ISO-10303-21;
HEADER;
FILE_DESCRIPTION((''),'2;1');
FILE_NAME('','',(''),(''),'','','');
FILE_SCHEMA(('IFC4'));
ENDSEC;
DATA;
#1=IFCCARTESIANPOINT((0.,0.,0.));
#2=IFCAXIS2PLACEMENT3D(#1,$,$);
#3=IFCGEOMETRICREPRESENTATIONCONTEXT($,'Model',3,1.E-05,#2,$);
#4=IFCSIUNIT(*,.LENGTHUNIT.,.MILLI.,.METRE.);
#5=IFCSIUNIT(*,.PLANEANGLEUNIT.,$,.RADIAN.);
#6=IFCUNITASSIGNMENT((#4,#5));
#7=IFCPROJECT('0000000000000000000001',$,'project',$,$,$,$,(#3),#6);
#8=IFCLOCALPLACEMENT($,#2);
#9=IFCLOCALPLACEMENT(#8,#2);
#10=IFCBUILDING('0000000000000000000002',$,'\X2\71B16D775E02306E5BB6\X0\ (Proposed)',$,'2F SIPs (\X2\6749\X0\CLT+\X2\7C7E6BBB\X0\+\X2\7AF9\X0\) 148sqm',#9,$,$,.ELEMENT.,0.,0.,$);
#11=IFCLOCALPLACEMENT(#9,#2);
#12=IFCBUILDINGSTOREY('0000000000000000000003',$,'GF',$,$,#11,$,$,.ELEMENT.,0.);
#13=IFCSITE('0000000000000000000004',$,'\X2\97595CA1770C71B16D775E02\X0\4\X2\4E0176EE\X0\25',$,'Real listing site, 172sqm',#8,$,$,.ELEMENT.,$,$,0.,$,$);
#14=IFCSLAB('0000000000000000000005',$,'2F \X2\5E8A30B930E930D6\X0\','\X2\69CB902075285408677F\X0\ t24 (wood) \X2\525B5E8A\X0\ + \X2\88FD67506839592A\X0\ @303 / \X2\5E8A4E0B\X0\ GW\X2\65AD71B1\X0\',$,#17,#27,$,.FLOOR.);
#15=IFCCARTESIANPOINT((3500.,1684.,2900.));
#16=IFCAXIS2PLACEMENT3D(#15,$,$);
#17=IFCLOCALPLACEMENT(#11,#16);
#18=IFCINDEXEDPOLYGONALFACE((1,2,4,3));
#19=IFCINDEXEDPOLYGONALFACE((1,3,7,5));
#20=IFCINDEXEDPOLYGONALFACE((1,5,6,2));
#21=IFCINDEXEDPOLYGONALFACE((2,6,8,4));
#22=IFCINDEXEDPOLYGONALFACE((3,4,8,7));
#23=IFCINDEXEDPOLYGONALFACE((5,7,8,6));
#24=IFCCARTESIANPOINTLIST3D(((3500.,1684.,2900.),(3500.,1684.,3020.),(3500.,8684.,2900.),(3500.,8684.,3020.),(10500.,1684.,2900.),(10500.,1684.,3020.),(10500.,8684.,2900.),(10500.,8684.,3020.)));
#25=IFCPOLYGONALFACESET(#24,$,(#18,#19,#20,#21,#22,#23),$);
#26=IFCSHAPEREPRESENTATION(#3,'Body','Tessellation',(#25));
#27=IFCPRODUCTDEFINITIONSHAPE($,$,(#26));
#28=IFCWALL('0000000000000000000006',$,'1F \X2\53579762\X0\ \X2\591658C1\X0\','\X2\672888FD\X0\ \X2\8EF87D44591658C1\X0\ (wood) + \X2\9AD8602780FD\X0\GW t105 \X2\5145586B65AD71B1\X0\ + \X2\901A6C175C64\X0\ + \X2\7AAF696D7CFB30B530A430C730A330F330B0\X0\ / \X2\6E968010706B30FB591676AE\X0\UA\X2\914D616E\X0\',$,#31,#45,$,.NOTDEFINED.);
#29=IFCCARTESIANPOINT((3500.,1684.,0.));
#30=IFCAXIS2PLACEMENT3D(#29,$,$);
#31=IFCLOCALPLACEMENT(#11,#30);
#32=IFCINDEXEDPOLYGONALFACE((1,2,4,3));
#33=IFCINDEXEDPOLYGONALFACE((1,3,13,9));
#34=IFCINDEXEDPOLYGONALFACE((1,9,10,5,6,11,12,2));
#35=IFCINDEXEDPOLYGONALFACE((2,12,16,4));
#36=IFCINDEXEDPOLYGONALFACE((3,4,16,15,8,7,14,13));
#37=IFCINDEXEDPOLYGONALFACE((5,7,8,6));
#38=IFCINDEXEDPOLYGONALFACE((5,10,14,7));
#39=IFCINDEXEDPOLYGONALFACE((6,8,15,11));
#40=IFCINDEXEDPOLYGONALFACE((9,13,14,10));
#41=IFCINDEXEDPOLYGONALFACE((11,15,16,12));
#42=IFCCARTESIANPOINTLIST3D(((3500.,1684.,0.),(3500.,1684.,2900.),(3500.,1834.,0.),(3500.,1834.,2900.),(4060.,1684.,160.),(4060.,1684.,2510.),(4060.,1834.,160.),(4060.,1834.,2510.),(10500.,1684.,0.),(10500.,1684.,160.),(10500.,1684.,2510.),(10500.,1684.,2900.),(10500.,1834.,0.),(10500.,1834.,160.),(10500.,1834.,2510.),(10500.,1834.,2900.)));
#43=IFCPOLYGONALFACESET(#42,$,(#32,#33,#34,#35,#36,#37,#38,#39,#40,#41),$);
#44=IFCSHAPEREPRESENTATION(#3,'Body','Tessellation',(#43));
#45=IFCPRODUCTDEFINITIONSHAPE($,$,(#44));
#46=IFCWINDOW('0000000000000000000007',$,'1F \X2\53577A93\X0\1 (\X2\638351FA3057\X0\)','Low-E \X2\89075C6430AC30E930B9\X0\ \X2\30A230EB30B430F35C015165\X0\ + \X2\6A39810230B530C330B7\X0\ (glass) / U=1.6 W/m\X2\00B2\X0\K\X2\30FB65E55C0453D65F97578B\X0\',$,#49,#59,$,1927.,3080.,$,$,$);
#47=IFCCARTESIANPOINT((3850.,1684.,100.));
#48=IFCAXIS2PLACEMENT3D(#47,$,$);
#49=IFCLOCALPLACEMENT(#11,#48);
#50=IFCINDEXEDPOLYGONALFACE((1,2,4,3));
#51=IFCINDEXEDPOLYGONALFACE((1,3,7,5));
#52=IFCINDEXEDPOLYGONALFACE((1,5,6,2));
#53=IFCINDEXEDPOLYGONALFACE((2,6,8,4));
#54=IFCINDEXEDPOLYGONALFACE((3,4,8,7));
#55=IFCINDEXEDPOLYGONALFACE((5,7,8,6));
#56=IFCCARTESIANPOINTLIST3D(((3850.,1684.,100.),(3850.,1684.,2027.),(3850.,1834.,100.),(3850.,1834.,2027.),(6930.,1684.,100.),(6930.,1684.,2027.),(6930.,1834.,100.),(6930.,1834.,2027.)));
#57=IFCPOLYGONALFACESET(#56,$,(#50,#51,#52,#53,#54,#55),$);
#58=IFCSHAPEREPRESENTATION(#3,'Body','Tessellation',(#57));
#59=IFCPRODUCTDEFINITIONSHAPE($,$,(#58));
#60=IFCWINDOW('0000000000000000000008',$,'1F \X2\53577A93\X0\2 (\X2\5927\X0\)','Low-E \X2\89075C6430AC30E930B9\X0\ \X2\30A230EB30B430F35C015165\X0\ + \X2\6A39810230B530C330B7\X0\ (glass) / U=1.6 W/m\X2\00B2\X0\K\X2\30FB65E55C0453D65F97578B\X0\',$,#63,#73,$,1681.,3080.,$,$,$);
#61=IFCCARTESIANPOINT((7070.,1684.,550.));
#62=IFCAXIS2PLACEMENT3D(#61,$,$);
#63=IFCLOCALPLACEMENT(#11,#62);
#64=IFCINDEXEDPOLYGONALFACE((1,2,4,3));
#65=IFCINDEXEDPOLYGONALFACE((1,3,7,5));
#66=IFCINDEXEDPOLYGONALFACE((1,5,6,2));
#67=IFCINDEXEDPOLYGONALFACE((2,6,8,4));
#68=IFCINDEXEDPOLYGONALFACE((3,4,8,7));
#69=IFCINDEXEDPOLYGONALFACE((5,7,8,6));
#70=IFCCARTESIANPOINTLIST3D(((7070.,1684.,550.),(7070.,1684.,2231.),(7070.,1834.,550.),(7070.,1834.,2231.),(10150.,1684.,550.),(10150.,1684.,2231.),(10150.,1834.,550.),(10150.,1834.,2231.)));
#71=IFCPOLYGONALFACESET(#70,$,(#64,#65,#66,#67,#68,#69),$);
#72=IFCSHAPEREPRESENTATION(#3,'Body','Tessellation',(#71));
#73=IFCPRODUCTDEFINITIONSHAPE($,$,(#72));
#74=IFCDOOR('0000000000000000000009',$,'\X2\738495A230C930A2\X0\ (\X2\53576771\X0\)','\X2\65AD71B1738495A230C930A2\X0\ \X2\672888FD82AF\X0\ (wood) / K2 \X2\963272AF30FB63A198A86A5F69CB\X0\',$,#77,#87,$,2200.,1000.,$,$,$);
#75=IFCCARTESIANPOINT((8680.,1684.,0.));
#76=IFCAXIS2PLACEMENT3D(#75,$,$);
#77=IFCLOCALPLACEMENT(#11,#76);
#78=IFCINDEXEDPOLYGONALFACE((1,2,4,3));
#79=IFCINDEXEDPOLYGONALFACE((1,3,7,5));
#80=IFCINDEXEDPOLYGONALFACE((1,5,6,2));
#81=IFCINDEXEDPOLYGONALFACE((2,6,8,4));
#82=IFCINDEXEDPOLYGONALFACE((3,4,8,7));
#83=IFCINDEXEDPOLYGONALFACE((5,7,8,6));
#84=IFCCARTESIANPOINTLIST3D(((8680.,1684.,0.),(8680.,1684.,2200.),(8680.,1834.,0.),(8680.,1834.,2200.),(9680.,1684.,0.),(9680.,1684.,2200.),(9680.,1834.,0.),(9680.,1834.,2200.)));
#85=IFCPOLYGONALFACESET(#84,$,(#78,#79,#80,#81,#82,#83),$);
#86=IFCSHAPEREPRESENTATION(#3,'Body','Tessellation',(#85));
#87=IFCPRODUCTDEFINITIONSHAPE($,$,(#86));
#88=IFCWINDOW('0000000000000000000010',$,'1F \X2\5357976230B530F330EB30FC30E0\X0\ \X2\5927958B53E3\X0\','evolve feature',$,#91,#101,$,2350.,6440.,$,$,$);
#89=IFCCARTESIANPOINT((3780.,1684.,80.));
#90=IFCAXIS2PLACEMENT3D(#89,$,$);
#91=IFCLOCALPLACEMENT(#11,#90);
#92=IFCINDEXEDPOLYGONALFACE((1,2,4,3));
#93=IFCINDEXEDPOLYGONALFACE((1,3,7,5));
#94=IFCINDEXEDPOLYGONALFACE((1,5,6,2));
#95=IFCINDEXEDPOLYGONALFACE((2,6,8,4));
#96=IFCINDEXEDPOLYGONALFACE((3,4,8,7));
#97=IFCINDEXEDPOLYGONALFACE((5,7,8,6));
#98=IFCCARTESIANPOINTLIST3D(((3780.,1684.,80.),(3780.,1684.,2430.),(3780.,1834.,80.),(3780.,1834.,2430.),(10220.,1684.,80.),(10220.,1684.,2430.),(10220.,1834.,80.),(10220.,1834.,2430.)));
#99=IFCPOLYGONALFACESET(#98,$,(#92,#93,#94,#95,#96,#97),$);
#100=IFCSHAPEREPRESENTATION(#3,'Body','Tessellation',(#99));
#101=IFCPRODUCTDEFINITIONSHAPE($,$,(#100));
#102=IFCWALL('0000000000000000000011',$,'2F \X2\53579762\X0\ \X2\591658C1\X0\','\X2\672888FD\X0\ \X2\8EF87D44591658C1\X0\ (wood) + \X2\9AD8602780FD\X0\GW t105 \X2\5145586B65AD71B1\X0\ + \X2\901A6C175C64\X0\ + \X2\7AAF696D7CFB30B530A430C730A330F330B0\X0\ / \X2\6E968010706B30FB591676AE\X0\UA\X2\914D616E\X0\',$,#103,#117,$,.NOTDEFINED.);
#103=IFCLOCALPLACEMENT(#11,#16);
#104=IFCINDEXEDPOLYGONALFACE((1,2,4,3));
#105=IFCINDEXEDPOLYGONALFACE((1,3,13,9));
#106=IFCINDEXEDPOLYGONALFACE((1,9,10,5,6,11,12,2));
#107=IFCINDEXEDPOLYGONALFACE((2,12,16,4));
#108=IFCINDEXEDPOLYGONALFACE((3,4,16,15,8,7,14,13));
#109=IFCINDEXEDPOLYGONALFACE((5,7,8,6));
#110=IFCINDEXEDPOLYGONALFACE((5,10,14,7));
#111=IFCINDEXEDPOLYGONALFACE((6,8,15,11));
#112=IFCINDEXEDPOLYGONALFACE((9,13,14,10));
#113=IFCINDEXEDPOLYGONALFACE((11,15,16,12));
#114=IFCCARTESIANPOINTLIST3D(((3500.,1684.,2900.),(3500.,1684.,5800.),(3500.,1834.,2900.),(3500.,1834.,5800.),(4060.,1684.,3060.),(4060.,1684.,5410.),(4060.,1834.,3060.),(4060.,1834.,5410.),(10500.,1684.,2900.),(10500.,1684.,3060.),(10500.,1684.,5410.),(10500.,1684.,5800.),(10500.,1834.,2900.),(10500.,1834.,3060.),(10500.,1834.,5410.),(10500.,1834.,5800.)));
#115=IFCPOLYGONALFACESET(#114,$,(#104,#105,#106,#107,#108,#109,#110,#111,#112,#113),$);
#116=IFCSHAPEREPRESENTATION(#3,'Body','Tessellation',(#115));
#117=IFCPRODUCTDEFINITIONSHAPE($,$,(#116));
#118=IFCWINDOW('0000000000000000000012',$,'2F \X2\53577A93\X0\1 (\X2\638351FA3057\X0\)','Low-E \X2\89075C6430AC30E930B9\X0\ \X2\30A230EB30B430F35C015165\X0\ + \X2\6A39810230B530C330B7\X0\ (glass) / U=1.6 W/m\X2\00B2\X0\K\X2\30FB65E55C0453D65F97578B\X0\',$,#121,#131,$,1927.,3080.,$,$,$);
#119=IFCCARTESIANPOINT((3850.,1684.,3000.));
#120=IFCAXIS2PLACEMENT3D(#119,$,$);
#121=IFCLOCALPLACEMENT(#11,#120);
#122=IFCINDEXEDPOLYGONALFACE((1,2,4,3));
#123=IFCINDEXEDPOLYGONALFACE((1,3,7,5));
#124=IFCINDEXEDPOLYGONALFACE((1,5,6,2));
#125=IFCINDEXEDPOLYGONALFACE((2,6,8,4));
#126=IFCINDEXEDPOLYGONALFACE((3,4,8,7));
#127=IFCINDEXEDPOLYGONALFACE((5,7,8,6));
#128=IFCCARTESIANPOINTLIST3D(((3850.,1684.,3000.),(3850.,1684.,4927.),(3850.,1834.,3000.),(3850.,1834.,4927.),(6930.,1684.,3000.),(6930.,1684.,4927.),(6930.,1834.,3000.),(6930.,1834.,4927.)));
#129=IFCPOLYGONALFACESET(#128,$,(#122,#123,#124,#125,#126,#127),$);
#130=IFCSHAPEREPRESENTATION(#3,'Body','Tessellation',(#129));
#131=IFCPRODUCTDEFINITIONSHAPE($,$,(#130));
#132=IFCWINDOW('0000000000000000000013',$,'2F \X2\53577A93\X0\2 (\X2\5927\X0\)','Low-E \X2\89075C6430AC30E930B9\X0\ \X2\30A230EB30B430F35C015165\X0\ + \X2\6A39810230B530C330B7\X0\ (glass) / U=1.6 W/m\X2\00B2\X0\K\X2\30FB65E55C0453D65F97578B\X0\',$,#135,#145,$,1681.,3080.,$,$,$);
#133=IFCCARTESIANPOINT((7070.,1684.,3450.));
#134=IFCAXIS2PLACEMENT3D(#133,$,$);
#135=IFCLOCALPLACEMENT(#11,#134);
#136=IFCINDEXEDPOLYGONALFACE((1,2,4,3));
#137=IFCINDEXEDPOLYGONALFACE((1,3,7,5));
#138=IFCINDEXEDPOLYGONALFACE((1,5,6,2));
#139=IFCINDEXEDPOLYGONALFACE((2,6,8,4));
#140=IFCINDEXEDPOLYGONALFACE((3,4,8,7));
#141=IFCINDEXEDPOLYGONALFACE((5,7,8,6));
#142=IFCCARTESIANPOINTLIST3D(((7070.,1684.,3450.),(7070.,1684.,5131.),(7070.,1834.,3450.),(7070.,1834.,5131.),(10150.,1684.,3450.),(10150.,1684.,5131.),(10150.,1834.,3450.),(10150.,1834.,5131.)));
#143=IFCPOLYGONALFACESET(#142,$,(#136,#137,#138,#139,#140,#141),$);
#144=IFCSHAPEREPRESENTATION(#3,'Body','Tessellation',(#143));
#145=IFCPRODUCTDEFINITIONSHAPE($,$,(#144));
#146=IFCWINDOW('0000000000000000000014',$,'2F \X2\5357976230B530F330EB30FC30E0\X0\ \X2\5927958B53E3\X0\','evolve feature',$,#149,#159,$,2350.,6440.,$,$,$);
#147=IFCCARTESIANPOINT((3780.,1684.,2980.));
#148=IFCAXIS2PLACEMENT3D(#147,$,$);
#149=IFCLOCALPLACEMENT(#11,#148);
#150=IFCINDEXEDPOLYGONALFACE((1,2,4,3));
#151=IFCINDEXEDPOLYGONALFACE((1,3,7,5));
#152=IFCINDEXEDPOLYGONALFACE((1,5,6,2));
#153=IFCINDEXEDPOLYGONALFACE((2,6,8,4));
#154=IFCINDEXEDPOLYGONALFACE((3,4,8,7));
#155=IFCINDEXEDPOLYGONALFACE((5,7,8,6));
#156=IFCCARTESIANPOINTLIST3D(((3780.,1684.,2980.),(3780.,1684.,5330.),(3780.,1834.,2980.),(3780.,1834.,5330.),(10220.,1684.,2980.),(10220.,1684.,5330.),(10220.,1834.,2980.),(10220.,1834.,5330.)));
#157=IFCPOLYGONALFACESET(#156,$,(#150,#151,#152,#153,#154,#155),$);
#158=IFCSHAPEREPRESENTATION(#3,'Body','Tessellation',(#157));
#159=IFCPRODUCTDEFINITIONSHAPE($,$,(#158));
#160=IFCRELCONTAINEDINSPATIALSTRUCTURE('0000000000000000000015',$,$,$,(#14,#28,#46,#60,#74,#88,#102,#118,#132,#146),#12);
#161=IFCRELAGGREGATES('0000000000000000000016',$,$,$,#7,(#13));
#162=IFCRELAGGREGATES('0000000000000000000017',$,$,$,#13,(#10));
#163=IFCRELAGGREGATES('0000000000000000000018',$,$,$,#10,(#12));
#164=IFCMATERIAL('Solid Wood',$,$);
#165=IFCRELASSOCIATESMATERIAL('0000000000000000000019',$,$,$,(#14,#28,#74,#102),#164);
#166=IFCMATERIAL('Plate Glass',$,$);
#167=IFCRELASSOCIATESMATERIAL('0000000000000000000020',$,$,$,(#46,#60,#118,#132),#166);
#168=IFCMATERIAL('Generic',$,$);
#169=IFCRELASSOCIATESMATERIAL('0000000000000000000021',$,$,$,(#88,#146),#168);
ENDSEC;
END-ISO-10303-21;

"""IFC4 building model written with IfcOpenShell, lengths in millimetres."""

from ifc_helpers import new_model, si_unit, frame, frame_2d, origin, place, context, project, spatial, rectangle, extrude, material, element, fill, save


model = new_model("IFC4")

# Units and contexts
model_context = context("Model", 3, precision=1e-05, world=origin())
ifc_project = project(units=[si_unit("LENGTHUNIT", "METRE", prefix="MILLI"), si_unit("PLANEANGLEUNIT", "RADIAN")], contexts=[model_context])

# Site, building, storey
site_placement = place(None, origin())
site = spatial("IfcSite", under=ifc_project, at=site_placement, Name="静岡県熱海市4丁目25", ObjectType="Real listing site, 172sqm", CompositionType="ELEMENT", RefElevation=0.0)
building_placement = place(site_placement, origin())
building = spatial("IfcBuilding", under=site, at=building_placement, Name="熱海市の家 (Proposed)", ObjectType="2F SIPs (杉CLT+籾殻+竹) 148sqm", CompositionType="ELEMENT", ElevationOfRefHeight=0.0, ElevationOfTerrain=0.0)
storey_placement = place(building_placement, origin())
storey = spatial("IfcBuildingStorey", under=building, at=storey_placement, Name="GF", CompositionType="ELEMENT", Elevation=0.0)

# Slab
ifc_material_1 = material(Name="Solid Wood")
slab_1_placement = place(storey_placement, frame((3500.0, 1684.0, 2900.0)))
element("IfcSlab", 1, at=slab_1_placement, inside=storey, material=ifc_material_1, Name="2F 床スラブ", Description="構造用合板 t24 (wood) 剛床 + 製材根太 @303 / 床下 GW断熱", PredefinedType="FLOOR", context=model_context, shape_type="SweptSolid", body=[
    extrude(rectangle(XDim=7000.0, YDim=7000.0, at=frame_2d((3500.0, 3500.0))), frame((3500.0, 1684.0, 2900.0)), (0.0, 0.0, 1.0), 120.0),
])
ifc_material_2 = material(Name="Generic")

# Wall, openings, windows, door
wall_1_placement = place(storey_placement, frame((3500.0, 1684.0, 0.0)))
wall_1 = element("IfcWall", 2, at=wall_1_placement, inside=storey, material=ifc_material_1, Name="1F 南面 外壁", Description="木製 軸組外壁 (wood) + 高性能GW t105 充填断熱 + 通気層 + 窯業系サイディング / 準耐火・外皮UA配慮", PredefinedType="NOTDEFINED", context=model_context, shape_type="SweptSolid", body=[
    extrude(rectangle(XDim=7000.0, YDim=150.0, at=frame_2d((3500.0, 75.0))), frame((3500.0, 1684.0, 0.0)), (0.0, 0.0, 1.0), 2900.0),
])
opening_1_placement = place(storey_placement, frame((3850.0, 1684.0, 100.0)))
opening_1 = element("IfcOpeningElement", 3, at=opening_1_placement, cuts=wall_1, PredefinedType="NOTDEFINED", context=model_context, shape_type="SweptSolid", body=[
    extrude(rectangle(XDim=3080.0, YDim=150.0, at=frame_2d((1540.0, 75.0))), frame((3850.0, 1684.0, 100.0)), (0.0, 0.0, 1.0), 1927.0),
])
opening_2_placement = place(storey_placement, frame((7070.0, 1684.0, 550.0)))
opening_2 = element("IfcOpeningElement", 4, at=opening_2_placement, cuts=wall_1, PredefinedType="NOTDEFINED", context=model_context, shape_type="SweptSolid", body=[
    extrude(rectangle(XDim=3080.0, YDim=150.0, at=frame_2d((1540.0, 75.0))), frame((7070.0, 1684.0, 550.0)), (0.0, 0.0, 1.0), 1681.0),
])
opening_3_placement = place(storey_placement, frame((8680.0, 1684.0, 0.0)))
opening_3 = element("IfcOpeningElement", 5, at=opening_3_placement, cuts=wall_1, PredefinedType="NOTDEFINED", context=model_context, shape_type="SweptSolid", body=[
    extrude(rectangle(XDim=1000.0, YDim=150.0, at=frame_2d((500.0, 75.0))), frame((8680.0, 1684.0, 0.0)), (0.0, 0.0, 1.0), 2200.0),
])
opening_4_placement = place(storey_placement, frame((3780.0, 1684.0, 80.0)))
opening_4 = element("IfcOpeningElement", 6, at=opening_4_placement, cuts=wall_1, PredefinedType="NOTDEFINED", context=model_context, shape_type="SweptSolid", body=[
    extrude(rectangle(XDim=6440.0, YDim=150.0, at=frame_2d((3220.0, 75.0))), frame((3780.0, 1684.0, 80.0)), (0.0, 0.0, 1.0), 2350.0),
])
ifc_material_3 = material(Name="Plate Glass")
window_1_placement = place(storey_placement, frame((3850.0, 1684.0, 100.0)))
window_1 = element("IfcWindow", 7, at=window_1_placement, inside=storey, material=ifc_material_3, Name="1F 南窓1 (掃出し)", Description="Low-E 複層ガラス アルゴン封入 + 樹脂サッシ (glass) / U=1.6 W/m²K・日射取得型", OverallHeight=1927.0, OverallWidth=3080.0, context=model_context, shape_type="SweptSolid", body=[
    extrude(rectangle(XDim=3080.0, YDim=150.0, at=frame_2d((1540.0, 75.0))), frame((3850.0, 1684.0, 100.0)), (0.0, 0.0, 1.0), 1927.0),
])
fill(opening_1, window_1)
window_2_placement = place(storey_placement, frame((7070.0, 1684.0, 550.0)))
window_2 = element("IfcWindow", 8, at=window_2_placement, inside=storey, material=ifc_material_3, Name="1F 南窓2 (大)", Description="Low-E 複層ガラス アルゴン封入 + 樹脂サッシ (glass) / U=1.6 W/m²K・日射取得型", OverallHeight=1681.0, OverallWidth=3080.0, context=model_context, shape_type="SweptSolid", body=[
    extrude(rectangle(XDim=3080.0, YDim=150.0, at=frame_2d((1540.0, 75.0))), frame((7070.0, 1684.0, 550.0)), (0.0, 0.0, 1.0), 1681.0),
])
fill(opening_2, window_2)
door_placement = place(storey_placement, frame((8680.0, 1684.0, 0.0)))
door = element("IfcDoor", 9, at=door_placement, inside=storey, material=ifc_material_1, Name="玄関ドア (南東)", Description="断熱玄関ドア 木製芯 (wood) / K2 防犯・採風機構", OverallHeight=2200.0, OverallWidth=1000.0, context=model_context, shape_type="SweptSolid", body=[
    extrude(rectangle(XDim=1000.0, YDim=150.0, at=frame_2d((500.0, 75.0))), frame((8680.0, 1684.0, 0.0)), (0.0, 0.0, 1.0), 2200.0),
])
fill(opening_3, door)
window_3_placement = place(storey_placement, frame((3780.0, 1684.0, 80.0)))
window_3 = element("IfcWindow", 10, at=window_3_placement, inside=storey, material=ifc_material_2, Name="1F 南面サンルーム 大開口", Description="evolve feature", OverallHeight=2350.0, OverallWidth=6440.0, context=model_context, shape_type="SweptSolid", body=[
    extrude(rectangle(XDim=6440.0, YDim=150.0, at=frame_2d((3220.0, 75.0))), frame((3780.0, 1684.0, 80.0)), (0.0, 0.0, 1.0), 2350.0),
])
fill(opening_4, window_3)

# Wall, openings, windows
wall_2_placement = place(storey_placement, frame((3500.0, 1684.0, 2900.0)))
wall_2 = element("IfcWall", 11, at=wall_2_placement, inside=storey, material=ifc_material_1, Name="2F 南面 外壁", Description="木製 軸組外壁 (wood) + 高性能GW t105 充填断熱 + 通気層 + 窯業系サイディング / 準耐火・外皮UA配慮", PredefinedType="NOTDEFINED", context=model_context, shape_type="SweptSolid", body=[
    extrude(rectangle(XDim=7000.0, YDim=150.0, at=frame_2d((3500.0, 75.0))), frame((3500.0, 1684.0, 2900.0)), (0.0, 0.0, 1.0), 2900.0),
])
opening_5_placement = place(storey_placement, frame((3850.0, 1684.0, 3000.0)))
opening_5 = element("IfcOpeningElement", 12, at=opening_5_placement, cuts=wall_2, PredefinedType="NOTDEFINED", context=model_context, shape_type="SweptSolid", body=[
    extrude(rectangle(XDim=3080.0, YDim=150.0, at=frame_2d((1540.0, 75.0))), frame((3850.0, 1684.0, 3000.0)), (0.0, 0.0, 1.0), 1927.0),
])
opening_6_placement = place(storey_placement, frame((7070.0, 1684.0, 3450.0)))
opening_6 = element("IfcOpeningElement", 13, at=opening_6_placement, cuts=wall_2, PredefinedType="NOTDEFINED", context=model_context, shape_type="SweptSolid", body=[
    extrude(rectangle(XDim=3080.0, YDim=150.0, at=frame_2d((1540.0, 75.0))), frame((7070.0, 1684.0, 3450.0)), (0.0, 0.0, 1.0), 1681.0),
])
opening_7_placement = place(storey_placement, frame((3780.0, 1684.0, 2980.0)))
opening_7 = element("IfcOpeningElement", 14, at=opening_7_placement, cuts=wall_2, PredefinedType="NOTDEFINED", context=model_context, shape_type="SweptSolid", body=[
    extrude(rectangle(XDim=6440.0, YDim=150.0, at=frame_2d((3220.0, 75.0))), frame((3780.0, 1684.0, 2980.0)), (0.0, 0.0, 1.0), 2350.0),
])
window_4_placement = place(storey_placement, frame((3850.0, 1684.0, 3000.0)))
window_4 = element("IfcWindow", 15, at=window_4_placement, inside=storey, material=ifc_material_3, Name="2F 南窓1 (掃出し)", Description="Low-E 複層ガラス アルゴン封入 + 樹脂サッシ (glass) / U=1.6 W/m²K・日射取得型", OverallHeight=1927.0, OverallWidth=3080.0, context=model_context, shape_type="SweptSolid", body=[
    extrude(rectangle(XDim=3080.0, YDim=150.0, at=frame_2d((1540.0, 75.0))), frame((3850.0, 1684.0, 3000.0)), (0.0, 0.0, 1.0), 1927.0),
])
fill(opening_5, window_4)
window_5_placement = place(storey_placement, frame((7070.0, 1684.0, 3450.0)))
window_5 = element("IfcWindow", 16, at=window_5_placement, inside=storey, material=ifc_material_3, Name="2F 南窓2 (大)", Description="Low-E 複層ガラス アルゴン封入 + 樹脂サッシ (glass) / U=1.6 W/m²K・日射取得型", OverallHeight=1681.0, OverallWidth=3080.0, context=model_context, shape_type="SweptSolid", body=[
    extrude(rectangle(XDim=3080.0, YDim=150.0, at=frame_2d((1540.0, 75.0))), frame((7070.0, 1684.0, 3450.0)), (0.0, 0.0, 1.0), 1681.0),
])
fill(opening_6, window_5)
window_6_placement = place(storey_placement, frame((3780.0, 1684.0, 2980.0)))
window_6 = element("IfcWindow", 17, at=window_6_placement, inside=storey, material=ifc_material_2, Name="2F 南面サンルーム 大開口", Description="evolve feature", OverallHeight=2350.0, OverallWidth=6440.0, context=model_context, shape_type="SweptSolid", body=[
    extrude(rectangle(XDim=6440.0, YDim=150.0, at=frame_2d((3220.0, 75.0))), frame((3780.0, 1684.0, 2980.0)), (0.0, 0.0, 1.0), 2350.0),
])
fill(opening_7, window_6)

save(model, "model.ifc")
